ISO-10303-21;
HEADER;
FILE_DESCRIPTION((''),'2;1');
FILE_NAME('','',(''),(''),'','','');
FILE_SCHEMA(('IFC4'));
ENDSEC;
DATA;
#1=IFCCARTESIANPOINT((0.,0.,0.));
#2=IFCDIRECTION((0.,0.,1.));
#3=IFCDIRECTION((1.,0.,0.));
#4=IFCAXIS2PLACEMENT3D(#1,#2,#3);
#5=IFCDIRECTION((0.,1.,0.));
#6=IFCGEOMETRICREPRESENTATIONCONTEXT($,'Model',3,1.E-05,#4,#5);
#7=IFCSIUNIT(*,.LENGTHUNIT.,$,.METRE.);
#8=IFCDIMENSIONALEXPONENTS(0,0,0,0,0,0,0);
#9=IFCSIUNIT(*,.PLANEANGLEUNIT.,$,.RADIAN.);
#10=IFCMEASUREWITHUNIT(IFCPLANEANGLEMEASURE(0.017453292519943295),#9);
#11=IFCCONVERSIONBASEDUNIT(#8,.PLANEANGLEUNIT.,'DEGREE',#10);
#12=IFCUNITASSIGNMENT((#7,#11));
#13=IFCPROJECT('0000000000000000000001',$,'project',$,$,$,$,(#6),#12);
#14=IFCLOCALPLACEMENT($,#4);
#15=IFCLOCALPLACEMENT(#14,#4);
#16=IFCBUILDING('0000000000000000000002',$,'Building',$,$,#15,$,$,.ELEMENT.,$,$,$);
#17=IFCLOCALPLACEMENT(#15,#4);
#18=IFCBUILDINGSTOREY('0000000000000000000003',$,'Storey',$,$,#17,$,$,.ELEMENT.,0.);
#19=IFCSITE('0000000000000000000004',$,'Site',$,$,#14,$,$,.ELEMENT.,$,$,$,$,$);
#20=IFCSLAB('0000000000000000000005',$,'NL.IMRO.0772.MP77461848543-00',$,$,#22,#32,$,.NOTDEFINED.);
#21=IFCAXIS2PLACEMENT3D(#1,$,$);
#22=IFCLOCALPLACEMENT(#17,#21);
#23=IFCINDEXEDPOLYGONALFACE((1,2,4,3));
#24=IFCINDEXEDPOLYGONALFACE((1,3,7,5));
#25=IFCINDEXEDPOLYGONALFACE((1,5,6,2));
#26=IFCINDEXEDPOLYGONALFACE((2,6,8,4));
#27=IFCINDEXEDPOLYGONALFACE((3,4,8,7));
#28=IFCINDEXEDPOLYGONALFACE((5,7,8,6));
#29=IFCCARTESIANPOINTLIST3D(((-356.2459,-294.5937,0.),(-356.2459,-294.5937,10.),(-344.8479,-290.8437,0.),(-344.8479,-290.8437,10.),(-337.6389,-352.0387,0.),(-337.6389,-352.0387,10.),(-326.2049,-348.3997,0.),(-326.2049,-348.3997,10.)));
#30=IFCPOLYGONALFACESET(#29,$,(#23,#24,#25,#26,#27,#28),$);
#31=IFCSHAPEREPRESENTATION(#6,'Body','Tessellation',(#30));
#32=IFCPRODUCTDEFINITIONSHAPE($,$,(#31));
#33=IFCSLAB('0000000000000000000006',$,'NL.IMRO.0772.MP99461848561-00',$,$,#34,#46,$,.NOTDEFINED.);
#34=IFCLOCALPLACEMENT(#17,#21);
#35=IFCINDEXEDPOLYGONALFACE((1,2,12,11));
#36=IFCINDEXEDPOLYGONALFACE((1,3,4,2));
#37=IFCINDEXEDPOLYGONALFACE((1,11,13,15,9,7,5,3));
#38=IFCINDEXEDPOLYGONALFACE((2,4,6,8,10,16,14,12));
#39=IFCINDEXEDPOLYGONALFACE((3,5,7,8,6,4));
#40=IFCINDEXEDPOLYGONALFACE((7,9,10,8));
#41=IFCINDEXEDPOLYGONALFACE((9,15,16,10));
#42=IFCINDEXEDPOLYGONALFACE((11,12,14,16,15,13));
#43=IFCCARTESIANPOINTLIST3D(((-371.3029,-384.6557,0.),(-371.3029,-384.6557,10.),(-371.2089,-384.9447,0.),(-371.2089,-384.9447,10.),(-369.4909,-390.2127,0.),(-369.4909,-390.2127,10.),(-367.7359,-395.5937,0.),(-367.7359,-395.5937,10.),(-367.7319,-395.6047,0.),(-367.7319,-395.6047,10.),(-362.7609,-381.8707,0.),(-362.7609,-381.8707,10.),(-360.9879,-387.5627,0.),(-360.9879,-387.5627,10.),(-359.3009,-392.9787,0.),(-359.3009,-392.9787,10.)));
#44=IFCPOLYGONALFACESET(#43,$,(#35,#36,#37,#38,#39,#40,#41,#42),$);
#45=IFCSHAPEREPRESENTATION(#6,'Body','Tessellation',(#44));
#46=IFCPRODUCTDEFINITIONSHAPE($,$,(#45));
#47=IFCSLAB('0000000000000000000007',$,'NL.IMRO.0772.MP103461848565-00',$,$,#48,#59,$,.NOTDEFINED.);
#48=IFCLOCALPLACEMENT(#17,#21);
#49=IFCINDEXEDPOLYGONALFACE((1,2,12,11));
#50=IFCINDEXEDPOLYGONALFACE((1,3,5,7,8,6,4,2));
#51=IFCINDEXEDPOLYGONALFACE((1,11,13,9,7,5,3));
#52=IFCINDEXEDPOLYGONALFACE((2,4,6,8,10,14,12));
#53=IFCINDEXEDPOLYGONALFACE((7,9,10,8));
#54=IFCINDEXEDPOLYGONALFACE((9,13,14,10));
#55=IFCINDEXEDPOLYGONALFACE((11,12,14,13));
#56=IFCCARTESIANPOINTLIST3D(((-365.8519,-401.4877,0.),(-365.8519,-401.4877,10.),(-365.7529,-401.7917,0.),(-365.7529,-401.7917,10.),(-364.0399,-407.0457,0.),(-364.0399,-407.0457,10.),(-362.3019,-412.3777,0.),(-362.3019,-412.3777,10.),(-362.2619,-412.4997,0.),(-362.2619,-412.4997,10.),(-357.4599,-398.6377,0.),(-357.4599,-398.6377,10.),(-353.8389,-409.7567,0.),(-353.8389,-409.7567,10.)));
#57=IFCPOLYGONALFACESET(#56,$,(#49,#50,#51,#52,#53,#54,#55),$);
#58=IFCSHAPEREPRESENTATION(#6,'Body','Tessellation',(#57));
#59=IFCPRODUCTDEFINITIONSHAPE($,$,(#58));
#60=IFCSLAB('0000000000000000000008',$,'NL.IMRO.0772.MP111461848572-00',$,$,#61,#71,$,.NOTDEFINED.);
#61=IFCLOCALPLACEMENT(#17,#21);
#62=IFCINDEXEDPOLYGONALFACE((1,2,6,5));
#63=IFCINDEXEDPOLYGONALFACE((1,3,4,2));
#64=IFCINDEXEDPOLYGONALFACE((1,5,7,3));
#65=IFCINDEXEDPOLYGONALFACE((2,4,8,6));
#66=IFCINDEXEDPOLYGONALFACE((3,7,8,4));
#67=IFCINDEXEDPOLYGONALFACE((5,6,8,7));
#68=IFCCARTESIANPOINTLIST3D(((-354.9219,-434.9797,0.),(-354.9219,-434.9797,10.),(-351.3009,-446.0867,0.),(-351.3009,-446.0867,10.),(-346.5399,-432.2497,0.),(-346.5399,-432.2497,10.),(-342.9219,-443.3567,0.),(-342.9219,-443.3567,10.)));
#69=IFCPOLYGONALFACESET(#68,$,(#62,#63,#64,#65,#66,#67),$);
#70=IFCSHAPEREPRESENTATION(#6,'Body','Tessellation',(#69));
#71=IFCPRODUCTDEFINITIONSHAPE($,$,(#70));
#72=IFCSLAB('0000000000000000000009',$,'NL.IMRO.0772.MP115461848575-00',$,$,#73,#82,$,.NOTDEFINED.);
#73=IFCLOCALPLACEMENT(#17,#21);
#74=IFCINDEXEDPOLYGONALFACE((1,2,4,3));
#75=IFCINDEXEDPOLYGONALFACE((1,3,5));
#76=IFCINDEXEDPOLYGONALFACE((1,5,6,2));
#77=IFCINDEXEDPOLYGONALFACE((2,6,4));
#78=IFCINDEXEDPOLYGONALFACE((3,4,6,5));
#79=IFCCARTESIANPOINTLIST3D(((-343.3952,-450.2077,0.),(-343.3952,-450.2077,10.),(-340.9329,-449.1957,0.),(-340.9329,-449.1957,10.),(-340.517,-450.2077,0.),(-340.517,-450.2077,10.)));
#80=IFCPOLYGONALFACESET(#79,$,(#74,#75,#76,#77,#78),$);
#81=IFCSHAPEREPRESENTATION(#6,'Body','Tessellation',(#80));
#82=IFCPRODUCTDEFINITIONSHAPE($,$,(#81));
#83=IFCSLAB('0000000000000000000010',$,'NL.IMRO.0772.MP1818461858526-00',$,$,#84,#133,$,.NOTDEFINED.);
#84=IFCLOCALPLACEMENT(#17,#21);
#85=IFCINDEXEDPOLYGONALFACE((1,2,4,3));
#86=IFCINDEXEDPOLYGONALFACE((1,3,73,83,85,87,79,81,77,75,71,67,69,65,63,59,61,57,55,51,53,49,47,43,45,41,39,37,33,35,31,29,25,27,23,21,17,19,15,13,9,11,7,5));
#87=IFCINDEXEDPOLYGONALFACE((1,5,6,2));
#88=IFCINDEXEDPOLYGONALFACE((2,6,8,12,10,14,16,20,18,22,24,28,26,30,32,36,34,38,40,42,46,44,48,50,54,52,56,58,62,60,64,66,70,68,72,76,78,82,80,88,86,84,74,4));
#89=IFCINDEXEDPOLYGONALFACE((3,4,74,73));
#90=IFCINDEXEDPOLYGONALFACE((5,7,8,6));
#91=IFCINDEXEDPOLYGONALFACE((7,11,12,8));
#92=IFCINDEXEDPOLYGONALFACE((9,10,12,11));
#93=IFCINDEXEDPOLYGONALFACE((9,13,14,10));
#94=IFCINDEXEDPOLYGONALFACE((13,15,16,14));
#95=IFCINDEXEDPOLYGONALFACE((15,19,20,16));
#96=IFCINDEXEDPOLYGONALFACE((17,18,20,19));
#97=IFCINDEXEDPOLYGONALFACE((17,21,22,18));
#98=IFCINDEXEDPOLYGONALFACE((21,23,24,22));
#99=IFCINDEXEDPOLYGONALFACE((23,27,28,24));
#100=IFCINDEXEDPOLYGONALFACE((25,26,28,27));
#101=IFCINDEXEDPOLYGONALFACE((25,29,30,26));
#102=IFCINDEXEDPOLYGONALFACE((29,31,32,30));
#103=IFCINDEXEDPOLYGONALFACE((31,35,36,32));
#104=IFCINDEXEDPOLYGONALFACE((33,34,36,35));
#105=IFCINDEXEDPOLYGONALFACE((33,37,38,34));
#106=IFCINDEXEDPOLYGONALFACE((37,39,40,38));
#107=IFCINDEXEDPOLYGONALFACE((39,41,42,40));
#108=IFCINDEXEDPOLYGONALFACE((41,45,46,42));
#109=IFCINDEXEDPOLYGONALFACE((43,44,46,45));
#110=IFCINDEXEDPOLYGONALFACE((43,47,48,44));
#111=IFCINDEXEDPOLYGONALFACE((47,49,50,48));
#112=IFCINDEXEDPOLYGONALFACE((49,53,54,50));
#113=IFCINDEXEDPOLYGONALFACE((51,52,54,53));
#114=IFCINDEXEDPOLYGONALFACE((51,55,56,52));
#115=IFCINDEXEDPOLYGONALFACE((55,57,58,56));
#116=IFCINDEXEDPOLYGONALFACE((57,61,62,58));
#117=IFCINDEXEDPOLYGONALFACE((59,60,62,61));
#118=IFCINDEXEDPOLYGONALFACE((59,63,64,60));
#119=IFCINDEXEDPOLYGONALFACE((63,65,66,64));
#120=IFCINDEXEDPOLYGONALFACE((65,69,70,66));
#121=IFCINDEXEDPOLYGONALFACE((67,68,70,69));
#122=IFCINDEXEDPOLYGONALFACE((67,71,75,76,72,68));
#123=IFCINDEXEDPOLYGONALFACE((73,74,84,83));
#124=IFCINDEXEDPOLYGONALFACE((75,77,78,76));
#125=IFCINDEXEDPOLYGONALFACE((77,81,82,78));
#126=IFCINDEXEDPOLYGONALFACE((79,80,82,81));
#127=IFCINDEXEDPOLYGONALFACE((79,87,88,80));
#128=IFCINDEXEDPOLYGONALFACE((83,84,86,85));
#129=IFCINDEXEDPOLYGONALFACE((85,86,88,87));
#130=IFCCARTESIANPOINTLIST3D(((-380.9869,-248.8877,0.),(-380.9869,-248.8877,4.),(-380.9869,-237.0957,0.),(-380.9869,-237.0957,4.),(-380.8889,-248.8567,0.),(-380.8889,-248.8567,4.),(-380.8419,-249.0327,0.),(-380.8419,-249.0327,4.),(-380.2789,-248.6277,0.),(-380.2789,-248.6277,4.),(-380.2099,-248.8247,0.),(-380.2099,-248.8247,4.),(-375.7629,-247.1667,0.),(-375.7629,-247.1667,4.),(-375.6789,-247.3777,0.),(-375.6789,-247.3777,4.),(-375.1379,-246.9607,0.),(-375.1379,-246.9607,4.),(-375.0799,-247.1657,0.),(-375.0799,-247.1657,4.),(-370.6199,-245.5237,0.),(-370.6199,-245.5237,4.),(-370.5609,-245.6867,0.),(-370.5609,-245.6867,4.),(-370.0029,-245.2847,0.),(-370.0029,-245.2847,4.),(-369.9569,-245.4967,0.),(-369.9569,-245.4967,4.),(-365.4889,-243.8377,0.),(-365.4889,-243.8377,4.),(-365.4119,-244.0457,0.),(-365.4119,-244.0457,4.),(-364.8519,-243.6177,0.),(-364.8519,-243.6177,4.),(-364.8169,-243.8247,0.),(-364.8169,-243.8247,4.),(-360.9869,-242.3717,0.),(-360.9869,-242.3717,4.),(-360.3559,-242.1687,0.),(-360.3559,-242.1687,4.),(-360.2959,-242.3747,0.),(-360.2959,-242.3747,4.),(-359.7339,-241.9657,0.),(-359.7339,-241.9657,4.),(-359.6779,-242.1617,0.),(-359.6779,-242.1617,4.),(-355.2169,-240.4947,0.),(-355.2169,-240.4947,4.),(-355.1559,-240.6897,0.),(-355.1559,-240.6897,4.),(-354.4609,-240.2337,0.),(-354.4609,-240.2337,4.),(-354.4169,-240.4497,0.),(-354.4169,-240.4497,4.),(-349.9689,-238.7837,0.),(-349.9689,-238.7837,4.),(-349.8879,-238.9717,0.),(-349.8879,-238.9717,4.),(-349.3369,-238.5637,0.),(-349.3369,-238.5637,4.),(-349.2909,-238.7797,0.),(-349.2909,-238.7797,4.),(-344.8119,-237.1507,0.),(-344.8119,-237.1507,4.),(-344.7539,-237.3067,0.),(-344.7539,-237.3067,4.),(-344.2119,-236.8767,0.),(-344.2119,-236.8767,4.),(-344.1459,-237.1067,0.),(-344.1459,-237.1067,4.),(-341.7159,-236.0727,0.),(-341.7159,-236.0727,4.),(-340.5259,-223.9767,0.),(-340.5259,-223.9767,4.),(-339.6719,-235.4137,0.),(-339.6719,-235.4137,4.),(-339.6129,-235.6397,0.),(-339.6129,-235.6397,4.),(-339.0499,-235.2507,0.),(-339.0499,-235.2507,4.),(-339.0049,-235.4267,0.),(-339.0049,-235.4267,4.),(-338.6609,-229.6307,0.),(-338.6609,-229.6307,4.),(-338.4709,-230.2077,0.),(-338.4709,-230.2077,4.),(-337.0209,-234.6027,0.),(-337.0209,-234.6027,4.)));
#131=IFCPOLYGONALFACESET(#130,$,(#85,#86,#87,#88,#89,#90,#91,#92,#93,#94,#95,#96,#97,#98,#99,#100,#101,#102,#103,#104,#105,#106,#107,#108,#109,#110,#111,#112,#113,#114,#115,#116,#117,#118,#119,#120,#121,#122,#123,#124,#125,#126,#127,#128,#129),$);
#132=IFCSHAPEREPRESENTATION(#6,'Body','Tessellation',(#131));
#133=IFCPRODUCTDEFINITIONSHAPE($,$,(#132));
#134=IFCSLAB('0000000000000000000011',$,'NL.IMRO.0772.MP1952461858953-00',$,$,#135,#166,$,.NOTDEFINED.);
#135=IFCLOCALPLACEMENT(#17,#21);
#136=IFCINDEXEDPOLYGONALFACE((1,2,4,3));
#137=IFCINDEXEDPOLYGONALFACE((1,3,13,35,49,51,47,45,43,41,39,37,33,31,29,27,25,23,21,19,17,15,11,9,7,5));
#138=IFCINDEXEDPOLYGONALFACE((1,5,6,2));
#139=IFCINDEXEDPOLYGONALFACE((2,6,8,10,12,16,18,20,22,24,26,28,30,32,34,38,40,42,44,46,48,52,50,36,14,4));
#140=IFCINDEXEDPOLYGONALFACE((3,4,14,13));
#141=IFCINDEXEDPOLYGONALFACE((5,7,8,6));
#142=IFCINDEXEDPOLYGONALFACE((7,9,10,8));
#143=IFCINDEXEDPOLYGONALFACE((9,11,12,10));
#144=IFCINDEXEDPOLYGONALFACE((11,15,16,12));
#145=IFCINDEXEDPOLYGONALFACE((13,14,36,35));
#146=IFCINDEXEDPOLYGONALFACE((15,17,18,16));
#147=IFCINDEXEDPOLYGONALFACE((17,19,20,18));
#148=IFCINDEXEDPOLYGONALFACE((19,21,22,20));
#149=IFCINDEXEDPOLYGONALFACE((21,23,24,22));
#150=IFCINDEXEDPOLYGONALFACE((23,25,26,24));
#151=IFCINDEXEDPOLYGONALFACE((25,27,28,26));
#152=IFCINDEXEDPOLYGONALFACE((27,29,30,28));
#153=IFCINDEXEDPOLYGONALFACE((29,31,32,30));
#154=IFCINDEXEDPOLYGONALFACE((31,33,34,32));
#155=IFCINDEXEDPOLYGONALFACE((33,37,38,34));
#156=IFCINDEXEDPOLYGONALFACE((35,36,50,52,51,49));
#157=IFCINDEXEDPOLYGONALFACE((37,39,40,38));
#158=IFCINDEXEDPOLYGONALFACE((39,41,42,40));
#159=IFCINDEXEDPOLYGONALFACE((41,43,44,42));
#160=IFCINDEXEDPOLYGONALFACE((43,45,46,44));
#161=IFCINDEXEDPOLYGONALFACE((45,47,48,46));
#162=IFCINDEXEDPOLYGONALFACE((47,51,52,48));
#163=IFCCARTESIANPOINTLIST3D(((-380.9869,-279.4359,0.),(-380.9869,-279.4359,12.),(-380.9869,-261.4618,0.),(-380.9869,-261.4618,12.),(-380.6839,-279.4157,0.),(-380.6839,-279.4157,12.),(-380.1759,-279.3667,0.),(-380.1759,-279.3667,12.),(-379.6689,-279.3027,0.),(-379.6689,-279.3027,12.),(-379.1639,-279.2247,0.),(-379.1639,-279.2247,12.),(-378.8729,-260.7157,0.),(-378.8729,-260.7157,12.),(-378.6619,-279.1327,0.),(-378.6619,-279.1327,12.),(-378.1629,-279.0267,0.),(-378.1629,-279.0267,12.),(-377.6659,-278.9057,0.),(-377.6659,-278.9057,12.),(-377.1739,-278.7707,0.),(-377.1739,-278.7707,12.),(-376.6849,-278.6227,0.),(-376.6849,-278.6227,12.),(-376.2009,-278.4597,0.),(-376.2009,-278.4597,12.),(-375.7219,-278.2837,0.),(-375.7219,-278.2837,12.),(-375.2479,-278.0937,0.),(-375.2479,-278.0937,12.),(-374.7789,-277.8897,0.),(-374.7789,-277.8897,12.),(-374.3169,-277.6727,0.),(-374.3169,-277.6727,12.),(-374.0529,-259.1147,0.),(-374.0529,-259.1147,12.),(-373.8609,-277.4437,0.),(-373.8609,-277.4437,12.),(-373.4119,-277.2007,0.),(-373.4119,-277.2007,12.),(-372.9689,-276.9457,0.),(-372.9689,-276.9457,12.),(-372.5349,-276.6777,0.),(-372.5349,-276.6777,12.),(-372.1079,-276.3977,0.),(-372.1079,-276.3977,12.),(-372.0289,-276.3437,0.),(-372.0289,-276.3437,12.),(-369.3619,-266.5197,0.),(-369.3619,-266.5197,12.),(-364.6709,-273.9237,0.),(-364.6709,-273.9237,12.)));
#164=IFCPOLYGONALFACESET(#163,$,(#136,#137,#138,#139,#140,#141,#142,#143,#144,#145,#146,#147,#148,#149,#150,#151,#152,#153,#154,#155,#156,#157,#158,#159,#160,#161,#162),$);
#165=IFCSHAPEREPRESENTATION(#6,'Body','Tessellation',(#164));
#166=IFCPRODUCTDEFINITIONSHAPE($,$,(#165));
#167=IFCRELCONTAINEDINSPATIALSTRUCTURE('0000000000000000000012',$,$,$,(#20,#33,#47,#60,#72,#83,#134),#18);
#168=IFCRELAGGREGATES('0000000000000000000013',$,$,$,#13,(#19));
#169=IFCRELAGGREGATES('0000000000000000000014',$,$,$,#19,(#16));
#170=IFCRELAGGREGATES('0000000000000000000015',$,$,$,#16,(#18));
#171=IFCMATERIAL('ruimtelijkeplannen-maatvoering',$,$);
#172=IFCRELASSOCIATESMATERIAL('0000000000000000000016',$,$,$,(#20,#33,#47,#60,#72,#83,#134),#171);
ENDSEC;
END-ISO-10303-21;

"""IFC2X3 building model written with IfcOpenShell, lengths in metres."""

from ifc_helpers import new_model, entity, si_unit, converted_unit, direction, origin_with_axes, place, context, project, spatial, polyline, outline, extrude, material, element, save


model = new_model("IFC2X3")

# Units and contexts
model_context = context("Model", 3, precision=1e-05, world=origin_with_axes(), true_north=direction((0.0, 1.0, 0.0)))
ifc_project = project(units=[si_unit("LENGTHUNIT", "METRE"), converted_unit("PLANEANGLEUNIT", "DEGREE", entity("IfcPlaneAngleMeasure", 0.017453292519943295), si_unit("PLANEANGLEUNIT", "RADIAN"), dimensions=[0, 0, 0, 0, 0, 0, 0])], contexts=[model_context])

# Site, building, storey
site_placement = place(None, origin_with_axes())
site = spatial("IfcSite", under=ifc_project, at=site_placement, Name="Site", CompositionType="ELEMENT")
building_placement = place(site_placement, origin_with_axes())
building = spatial("IfcBuilding", under=site, at=building_placement, Name="Building", CompositionType="ELEMENT")
storey_placement = place(building_placement, origin_with_axes())
storey = spatial("IfcBuildingStorey", under=building, at=storey_placement, Name="Storey", CompositionType="ELEMENT", Elevation=0.0)

# Slabs
ifc_material = material(Name="ruimtelijkeplannen-maatvoering")
slab_1_placement = place(storey_placement, origin_with_axes())
element("IfcSlab", 1, at=slab_1_placement, inside=storey, material=ifc_material, Name="NL.IMRO.0772.MP77461848543-00", PredefinedType="NOTDEFINED", context=model_context, shape_type="SweptSolid", body=[
    extrude(outline(polyline([(-337.6389, -352.0387), (-356.2459, -294.5937), (-344.8479, -290.8437), (-326.2049, -348.3997), (-337.6389, -352.0387)])), origin_with_axes(), (0.0, 0.0, 1.0), 10.0),
])
slab_2_placement = place(storey_placement, origin_with_axes())
element("IfcSlab", 2, at=slab_2_placement, inside=storey, material=ifc_material, Name="NL.IMRO.0772.MP99461848561-00", PredefinedType="NOTDEFINED", context=model_context, shape_type="SweptSolid", body=[
    extrude(outline(polyline([(-362.7609, -381.8707), (-360.9879, -387.5627), (-359.3009, -392.9787), (-367.7319, -395.6047), (-367.7359, -395.5937), (-369.4909, -390.2127), (-371.2089, -384.9447), (-371.3029, -384.6557), (-362.7609, -381.8707)])), origin_with_axes(), (0.0, 0.0, 1.0), 10.0),
])
slab_3_placement = place(storey_placement, origin_with_axes())
element("IfcSlab", 3, at=slab_3_placement, inside=storey, material=ifc_material, Name="NL.IMRO.0772.MP103461848565-00", PredefinedType="NOTDEFINED", context=model_context, shape_type="SweptSolid", body=[
    extrude(outline(polyline([(-357.4599, -398.6377), (-353.8389, -409.7567), (-362.2619, -412.4997), (-362.3019, -412.3777), (-364.0399, -407.0457), (-365.7529, -401.7917), (-365.8519, -401.4877), (-357.4599, -398.6377)])), origin_with_axes(), (0.0, 0.0, 1.0), 10.0),
])
slab_4_placement = place(storey_placement, origin_with_axes())
element("IfcSlab", 4, at=slab_4_placement, inside=storey, material=ifc_material, Name="NL.IMRO.0772.MP111461848572-00", PredefinedType="NOTDEFINED", context=model_context, shape_type="SweptSolid", body=[
    extrude(outline(polyline([(-354.9219, -434.9797), (-346.5399, -432.2497), (-342.9219, -443.3567), (-351.3009, -446.0867), (-354.9219, -434.9797)])), origin_with_axes(), (0.0, 0.0, 1.0), 10.0),
])
slab_5_placement = place(storey_placement, origin_with_axes())
element("IfcSlab", 5, at=slab_5_placement, inside=storey, material=ifc_material, Name="NL.IMRO.0772.MP115461848575-00", PredefinedType="NOTDEFINED", context=model_context, shape_type="SweptSolid", body=[
    extrude(outline(polyline([(-340.9329, -449.1957), (-340.517, -450.2077), (-343.3952, -450.2077), (-340.9329, -449.1957)])), origin_with_axes(), (0.0, 0.0, 1.0), 10.0),
])
slab_6_placement = place(storey_placement, origin_with_axes())
element("IfcSlab", 6, at=slab_6_placement, inside=storey, material=ifc_material, Name="NL.IMRO.0772.MP1818461858526-00", PredefinedType="NOTDEFINED", context=model_context, shape_type="SweptSolid", body=[
    extrude(outline(polyline([(-340.5259, -223.9767), (-338.6609, -229.6307), (-338.4709, -230.2077), (-337.0209, -234.6027), (-339.0499, -235.2507), (-339.0049, -235.4267), (-339.6129, -235.6397), (-339.6719, -235.4137), (-341.7159, -236.0727), (-344.2119, -236.8767), (-344.1459, -237.1067), (-344.7539, -237.3067), (-344.8119, -237.1507), (-349.3369, -238.5637), (-349.2909, -238.7797), (-349.8879, -238.9717), (-349.9689, -238.7837), (-354.4609, -240.2337), (-354.4169, -240.4497), (-355.1559, -240.6897), (-355.2169, -240.4947), (-359.7339, -241.9657), (-359.6779, -242.1617), (-360.2959, -242.3747), (-360.3559, -242.1687), (-360.9869, -242.3717), (-364.8519, -243.6177), (-364.8169, -243.8247), (-365.4119, -244.0457), (-365.4889, -243.8377), (-370.0029, -245.2847), (-369.9569, -245.4967), (-370.5609, -245.6867), (-370.6199, -245.5237), (-375.1379, -246.9607), (-375.0799, -247.1657), (-375.6789, -247.3777), (-375.7629, -247.1667), (-380.2789, -248.6277), (-380.2099, -248.8247), (-380.8419, -249.0327), (-380.8889, -248.8567), (-380.9869, -248.8877), (-380.9869, -237.0957), (-340.5259, -223.9767)])), origin_with_axes(), (0.0, 0.0, 1.0), 4.0),
])
slab_7_placement = place(storey_placement, origin_with_axes())
element("IfcSlab", 7, at=slab_7_placement, inside=storey, material=ifc_material, Name="NL.IMRO.0772.MP1952461858953-00", PredefinedType="NOTDEFINED", context=model_context, shape_type="SweptSolid", body=[
    extrude(outline(polyline([(-378.8729, -260.7157), (-374.0529, -259.1147), (-369.3619, -266.5197), (-364.6709, -273.9237), (-372.0289, -276.3437), (-372.1079, -276.3977), (-372.5349, -276.6777), (-372.9689, -276.9457), (-373.4119, -277.2007), (-373.8609, -277.4437), (-374.3169, -277.6727), (-374.7789, -277.8897), (-375.2479, -278.0937), (-375.7219, -278.2837), (-376.2009, -278.4597), (-376.6849, -278.6227), (-377.1739, -278.7707), (-377.6659, -278.9057), (-378.1629, -279.0267), (-378.6619, -279.1327), (-379.1639, -279.2247), (-379.6689, -279.3027), (-380.1759, -279.3667), (-380.6839, -279.4157), (-380.9869, -279.4359), (-380.9869, -261.4618), (-378.8729, -260.7157)])), origin_with_axes(), (0.0, 0.0, 1.0), 12.0),
])

save(model, "model.ifc")
